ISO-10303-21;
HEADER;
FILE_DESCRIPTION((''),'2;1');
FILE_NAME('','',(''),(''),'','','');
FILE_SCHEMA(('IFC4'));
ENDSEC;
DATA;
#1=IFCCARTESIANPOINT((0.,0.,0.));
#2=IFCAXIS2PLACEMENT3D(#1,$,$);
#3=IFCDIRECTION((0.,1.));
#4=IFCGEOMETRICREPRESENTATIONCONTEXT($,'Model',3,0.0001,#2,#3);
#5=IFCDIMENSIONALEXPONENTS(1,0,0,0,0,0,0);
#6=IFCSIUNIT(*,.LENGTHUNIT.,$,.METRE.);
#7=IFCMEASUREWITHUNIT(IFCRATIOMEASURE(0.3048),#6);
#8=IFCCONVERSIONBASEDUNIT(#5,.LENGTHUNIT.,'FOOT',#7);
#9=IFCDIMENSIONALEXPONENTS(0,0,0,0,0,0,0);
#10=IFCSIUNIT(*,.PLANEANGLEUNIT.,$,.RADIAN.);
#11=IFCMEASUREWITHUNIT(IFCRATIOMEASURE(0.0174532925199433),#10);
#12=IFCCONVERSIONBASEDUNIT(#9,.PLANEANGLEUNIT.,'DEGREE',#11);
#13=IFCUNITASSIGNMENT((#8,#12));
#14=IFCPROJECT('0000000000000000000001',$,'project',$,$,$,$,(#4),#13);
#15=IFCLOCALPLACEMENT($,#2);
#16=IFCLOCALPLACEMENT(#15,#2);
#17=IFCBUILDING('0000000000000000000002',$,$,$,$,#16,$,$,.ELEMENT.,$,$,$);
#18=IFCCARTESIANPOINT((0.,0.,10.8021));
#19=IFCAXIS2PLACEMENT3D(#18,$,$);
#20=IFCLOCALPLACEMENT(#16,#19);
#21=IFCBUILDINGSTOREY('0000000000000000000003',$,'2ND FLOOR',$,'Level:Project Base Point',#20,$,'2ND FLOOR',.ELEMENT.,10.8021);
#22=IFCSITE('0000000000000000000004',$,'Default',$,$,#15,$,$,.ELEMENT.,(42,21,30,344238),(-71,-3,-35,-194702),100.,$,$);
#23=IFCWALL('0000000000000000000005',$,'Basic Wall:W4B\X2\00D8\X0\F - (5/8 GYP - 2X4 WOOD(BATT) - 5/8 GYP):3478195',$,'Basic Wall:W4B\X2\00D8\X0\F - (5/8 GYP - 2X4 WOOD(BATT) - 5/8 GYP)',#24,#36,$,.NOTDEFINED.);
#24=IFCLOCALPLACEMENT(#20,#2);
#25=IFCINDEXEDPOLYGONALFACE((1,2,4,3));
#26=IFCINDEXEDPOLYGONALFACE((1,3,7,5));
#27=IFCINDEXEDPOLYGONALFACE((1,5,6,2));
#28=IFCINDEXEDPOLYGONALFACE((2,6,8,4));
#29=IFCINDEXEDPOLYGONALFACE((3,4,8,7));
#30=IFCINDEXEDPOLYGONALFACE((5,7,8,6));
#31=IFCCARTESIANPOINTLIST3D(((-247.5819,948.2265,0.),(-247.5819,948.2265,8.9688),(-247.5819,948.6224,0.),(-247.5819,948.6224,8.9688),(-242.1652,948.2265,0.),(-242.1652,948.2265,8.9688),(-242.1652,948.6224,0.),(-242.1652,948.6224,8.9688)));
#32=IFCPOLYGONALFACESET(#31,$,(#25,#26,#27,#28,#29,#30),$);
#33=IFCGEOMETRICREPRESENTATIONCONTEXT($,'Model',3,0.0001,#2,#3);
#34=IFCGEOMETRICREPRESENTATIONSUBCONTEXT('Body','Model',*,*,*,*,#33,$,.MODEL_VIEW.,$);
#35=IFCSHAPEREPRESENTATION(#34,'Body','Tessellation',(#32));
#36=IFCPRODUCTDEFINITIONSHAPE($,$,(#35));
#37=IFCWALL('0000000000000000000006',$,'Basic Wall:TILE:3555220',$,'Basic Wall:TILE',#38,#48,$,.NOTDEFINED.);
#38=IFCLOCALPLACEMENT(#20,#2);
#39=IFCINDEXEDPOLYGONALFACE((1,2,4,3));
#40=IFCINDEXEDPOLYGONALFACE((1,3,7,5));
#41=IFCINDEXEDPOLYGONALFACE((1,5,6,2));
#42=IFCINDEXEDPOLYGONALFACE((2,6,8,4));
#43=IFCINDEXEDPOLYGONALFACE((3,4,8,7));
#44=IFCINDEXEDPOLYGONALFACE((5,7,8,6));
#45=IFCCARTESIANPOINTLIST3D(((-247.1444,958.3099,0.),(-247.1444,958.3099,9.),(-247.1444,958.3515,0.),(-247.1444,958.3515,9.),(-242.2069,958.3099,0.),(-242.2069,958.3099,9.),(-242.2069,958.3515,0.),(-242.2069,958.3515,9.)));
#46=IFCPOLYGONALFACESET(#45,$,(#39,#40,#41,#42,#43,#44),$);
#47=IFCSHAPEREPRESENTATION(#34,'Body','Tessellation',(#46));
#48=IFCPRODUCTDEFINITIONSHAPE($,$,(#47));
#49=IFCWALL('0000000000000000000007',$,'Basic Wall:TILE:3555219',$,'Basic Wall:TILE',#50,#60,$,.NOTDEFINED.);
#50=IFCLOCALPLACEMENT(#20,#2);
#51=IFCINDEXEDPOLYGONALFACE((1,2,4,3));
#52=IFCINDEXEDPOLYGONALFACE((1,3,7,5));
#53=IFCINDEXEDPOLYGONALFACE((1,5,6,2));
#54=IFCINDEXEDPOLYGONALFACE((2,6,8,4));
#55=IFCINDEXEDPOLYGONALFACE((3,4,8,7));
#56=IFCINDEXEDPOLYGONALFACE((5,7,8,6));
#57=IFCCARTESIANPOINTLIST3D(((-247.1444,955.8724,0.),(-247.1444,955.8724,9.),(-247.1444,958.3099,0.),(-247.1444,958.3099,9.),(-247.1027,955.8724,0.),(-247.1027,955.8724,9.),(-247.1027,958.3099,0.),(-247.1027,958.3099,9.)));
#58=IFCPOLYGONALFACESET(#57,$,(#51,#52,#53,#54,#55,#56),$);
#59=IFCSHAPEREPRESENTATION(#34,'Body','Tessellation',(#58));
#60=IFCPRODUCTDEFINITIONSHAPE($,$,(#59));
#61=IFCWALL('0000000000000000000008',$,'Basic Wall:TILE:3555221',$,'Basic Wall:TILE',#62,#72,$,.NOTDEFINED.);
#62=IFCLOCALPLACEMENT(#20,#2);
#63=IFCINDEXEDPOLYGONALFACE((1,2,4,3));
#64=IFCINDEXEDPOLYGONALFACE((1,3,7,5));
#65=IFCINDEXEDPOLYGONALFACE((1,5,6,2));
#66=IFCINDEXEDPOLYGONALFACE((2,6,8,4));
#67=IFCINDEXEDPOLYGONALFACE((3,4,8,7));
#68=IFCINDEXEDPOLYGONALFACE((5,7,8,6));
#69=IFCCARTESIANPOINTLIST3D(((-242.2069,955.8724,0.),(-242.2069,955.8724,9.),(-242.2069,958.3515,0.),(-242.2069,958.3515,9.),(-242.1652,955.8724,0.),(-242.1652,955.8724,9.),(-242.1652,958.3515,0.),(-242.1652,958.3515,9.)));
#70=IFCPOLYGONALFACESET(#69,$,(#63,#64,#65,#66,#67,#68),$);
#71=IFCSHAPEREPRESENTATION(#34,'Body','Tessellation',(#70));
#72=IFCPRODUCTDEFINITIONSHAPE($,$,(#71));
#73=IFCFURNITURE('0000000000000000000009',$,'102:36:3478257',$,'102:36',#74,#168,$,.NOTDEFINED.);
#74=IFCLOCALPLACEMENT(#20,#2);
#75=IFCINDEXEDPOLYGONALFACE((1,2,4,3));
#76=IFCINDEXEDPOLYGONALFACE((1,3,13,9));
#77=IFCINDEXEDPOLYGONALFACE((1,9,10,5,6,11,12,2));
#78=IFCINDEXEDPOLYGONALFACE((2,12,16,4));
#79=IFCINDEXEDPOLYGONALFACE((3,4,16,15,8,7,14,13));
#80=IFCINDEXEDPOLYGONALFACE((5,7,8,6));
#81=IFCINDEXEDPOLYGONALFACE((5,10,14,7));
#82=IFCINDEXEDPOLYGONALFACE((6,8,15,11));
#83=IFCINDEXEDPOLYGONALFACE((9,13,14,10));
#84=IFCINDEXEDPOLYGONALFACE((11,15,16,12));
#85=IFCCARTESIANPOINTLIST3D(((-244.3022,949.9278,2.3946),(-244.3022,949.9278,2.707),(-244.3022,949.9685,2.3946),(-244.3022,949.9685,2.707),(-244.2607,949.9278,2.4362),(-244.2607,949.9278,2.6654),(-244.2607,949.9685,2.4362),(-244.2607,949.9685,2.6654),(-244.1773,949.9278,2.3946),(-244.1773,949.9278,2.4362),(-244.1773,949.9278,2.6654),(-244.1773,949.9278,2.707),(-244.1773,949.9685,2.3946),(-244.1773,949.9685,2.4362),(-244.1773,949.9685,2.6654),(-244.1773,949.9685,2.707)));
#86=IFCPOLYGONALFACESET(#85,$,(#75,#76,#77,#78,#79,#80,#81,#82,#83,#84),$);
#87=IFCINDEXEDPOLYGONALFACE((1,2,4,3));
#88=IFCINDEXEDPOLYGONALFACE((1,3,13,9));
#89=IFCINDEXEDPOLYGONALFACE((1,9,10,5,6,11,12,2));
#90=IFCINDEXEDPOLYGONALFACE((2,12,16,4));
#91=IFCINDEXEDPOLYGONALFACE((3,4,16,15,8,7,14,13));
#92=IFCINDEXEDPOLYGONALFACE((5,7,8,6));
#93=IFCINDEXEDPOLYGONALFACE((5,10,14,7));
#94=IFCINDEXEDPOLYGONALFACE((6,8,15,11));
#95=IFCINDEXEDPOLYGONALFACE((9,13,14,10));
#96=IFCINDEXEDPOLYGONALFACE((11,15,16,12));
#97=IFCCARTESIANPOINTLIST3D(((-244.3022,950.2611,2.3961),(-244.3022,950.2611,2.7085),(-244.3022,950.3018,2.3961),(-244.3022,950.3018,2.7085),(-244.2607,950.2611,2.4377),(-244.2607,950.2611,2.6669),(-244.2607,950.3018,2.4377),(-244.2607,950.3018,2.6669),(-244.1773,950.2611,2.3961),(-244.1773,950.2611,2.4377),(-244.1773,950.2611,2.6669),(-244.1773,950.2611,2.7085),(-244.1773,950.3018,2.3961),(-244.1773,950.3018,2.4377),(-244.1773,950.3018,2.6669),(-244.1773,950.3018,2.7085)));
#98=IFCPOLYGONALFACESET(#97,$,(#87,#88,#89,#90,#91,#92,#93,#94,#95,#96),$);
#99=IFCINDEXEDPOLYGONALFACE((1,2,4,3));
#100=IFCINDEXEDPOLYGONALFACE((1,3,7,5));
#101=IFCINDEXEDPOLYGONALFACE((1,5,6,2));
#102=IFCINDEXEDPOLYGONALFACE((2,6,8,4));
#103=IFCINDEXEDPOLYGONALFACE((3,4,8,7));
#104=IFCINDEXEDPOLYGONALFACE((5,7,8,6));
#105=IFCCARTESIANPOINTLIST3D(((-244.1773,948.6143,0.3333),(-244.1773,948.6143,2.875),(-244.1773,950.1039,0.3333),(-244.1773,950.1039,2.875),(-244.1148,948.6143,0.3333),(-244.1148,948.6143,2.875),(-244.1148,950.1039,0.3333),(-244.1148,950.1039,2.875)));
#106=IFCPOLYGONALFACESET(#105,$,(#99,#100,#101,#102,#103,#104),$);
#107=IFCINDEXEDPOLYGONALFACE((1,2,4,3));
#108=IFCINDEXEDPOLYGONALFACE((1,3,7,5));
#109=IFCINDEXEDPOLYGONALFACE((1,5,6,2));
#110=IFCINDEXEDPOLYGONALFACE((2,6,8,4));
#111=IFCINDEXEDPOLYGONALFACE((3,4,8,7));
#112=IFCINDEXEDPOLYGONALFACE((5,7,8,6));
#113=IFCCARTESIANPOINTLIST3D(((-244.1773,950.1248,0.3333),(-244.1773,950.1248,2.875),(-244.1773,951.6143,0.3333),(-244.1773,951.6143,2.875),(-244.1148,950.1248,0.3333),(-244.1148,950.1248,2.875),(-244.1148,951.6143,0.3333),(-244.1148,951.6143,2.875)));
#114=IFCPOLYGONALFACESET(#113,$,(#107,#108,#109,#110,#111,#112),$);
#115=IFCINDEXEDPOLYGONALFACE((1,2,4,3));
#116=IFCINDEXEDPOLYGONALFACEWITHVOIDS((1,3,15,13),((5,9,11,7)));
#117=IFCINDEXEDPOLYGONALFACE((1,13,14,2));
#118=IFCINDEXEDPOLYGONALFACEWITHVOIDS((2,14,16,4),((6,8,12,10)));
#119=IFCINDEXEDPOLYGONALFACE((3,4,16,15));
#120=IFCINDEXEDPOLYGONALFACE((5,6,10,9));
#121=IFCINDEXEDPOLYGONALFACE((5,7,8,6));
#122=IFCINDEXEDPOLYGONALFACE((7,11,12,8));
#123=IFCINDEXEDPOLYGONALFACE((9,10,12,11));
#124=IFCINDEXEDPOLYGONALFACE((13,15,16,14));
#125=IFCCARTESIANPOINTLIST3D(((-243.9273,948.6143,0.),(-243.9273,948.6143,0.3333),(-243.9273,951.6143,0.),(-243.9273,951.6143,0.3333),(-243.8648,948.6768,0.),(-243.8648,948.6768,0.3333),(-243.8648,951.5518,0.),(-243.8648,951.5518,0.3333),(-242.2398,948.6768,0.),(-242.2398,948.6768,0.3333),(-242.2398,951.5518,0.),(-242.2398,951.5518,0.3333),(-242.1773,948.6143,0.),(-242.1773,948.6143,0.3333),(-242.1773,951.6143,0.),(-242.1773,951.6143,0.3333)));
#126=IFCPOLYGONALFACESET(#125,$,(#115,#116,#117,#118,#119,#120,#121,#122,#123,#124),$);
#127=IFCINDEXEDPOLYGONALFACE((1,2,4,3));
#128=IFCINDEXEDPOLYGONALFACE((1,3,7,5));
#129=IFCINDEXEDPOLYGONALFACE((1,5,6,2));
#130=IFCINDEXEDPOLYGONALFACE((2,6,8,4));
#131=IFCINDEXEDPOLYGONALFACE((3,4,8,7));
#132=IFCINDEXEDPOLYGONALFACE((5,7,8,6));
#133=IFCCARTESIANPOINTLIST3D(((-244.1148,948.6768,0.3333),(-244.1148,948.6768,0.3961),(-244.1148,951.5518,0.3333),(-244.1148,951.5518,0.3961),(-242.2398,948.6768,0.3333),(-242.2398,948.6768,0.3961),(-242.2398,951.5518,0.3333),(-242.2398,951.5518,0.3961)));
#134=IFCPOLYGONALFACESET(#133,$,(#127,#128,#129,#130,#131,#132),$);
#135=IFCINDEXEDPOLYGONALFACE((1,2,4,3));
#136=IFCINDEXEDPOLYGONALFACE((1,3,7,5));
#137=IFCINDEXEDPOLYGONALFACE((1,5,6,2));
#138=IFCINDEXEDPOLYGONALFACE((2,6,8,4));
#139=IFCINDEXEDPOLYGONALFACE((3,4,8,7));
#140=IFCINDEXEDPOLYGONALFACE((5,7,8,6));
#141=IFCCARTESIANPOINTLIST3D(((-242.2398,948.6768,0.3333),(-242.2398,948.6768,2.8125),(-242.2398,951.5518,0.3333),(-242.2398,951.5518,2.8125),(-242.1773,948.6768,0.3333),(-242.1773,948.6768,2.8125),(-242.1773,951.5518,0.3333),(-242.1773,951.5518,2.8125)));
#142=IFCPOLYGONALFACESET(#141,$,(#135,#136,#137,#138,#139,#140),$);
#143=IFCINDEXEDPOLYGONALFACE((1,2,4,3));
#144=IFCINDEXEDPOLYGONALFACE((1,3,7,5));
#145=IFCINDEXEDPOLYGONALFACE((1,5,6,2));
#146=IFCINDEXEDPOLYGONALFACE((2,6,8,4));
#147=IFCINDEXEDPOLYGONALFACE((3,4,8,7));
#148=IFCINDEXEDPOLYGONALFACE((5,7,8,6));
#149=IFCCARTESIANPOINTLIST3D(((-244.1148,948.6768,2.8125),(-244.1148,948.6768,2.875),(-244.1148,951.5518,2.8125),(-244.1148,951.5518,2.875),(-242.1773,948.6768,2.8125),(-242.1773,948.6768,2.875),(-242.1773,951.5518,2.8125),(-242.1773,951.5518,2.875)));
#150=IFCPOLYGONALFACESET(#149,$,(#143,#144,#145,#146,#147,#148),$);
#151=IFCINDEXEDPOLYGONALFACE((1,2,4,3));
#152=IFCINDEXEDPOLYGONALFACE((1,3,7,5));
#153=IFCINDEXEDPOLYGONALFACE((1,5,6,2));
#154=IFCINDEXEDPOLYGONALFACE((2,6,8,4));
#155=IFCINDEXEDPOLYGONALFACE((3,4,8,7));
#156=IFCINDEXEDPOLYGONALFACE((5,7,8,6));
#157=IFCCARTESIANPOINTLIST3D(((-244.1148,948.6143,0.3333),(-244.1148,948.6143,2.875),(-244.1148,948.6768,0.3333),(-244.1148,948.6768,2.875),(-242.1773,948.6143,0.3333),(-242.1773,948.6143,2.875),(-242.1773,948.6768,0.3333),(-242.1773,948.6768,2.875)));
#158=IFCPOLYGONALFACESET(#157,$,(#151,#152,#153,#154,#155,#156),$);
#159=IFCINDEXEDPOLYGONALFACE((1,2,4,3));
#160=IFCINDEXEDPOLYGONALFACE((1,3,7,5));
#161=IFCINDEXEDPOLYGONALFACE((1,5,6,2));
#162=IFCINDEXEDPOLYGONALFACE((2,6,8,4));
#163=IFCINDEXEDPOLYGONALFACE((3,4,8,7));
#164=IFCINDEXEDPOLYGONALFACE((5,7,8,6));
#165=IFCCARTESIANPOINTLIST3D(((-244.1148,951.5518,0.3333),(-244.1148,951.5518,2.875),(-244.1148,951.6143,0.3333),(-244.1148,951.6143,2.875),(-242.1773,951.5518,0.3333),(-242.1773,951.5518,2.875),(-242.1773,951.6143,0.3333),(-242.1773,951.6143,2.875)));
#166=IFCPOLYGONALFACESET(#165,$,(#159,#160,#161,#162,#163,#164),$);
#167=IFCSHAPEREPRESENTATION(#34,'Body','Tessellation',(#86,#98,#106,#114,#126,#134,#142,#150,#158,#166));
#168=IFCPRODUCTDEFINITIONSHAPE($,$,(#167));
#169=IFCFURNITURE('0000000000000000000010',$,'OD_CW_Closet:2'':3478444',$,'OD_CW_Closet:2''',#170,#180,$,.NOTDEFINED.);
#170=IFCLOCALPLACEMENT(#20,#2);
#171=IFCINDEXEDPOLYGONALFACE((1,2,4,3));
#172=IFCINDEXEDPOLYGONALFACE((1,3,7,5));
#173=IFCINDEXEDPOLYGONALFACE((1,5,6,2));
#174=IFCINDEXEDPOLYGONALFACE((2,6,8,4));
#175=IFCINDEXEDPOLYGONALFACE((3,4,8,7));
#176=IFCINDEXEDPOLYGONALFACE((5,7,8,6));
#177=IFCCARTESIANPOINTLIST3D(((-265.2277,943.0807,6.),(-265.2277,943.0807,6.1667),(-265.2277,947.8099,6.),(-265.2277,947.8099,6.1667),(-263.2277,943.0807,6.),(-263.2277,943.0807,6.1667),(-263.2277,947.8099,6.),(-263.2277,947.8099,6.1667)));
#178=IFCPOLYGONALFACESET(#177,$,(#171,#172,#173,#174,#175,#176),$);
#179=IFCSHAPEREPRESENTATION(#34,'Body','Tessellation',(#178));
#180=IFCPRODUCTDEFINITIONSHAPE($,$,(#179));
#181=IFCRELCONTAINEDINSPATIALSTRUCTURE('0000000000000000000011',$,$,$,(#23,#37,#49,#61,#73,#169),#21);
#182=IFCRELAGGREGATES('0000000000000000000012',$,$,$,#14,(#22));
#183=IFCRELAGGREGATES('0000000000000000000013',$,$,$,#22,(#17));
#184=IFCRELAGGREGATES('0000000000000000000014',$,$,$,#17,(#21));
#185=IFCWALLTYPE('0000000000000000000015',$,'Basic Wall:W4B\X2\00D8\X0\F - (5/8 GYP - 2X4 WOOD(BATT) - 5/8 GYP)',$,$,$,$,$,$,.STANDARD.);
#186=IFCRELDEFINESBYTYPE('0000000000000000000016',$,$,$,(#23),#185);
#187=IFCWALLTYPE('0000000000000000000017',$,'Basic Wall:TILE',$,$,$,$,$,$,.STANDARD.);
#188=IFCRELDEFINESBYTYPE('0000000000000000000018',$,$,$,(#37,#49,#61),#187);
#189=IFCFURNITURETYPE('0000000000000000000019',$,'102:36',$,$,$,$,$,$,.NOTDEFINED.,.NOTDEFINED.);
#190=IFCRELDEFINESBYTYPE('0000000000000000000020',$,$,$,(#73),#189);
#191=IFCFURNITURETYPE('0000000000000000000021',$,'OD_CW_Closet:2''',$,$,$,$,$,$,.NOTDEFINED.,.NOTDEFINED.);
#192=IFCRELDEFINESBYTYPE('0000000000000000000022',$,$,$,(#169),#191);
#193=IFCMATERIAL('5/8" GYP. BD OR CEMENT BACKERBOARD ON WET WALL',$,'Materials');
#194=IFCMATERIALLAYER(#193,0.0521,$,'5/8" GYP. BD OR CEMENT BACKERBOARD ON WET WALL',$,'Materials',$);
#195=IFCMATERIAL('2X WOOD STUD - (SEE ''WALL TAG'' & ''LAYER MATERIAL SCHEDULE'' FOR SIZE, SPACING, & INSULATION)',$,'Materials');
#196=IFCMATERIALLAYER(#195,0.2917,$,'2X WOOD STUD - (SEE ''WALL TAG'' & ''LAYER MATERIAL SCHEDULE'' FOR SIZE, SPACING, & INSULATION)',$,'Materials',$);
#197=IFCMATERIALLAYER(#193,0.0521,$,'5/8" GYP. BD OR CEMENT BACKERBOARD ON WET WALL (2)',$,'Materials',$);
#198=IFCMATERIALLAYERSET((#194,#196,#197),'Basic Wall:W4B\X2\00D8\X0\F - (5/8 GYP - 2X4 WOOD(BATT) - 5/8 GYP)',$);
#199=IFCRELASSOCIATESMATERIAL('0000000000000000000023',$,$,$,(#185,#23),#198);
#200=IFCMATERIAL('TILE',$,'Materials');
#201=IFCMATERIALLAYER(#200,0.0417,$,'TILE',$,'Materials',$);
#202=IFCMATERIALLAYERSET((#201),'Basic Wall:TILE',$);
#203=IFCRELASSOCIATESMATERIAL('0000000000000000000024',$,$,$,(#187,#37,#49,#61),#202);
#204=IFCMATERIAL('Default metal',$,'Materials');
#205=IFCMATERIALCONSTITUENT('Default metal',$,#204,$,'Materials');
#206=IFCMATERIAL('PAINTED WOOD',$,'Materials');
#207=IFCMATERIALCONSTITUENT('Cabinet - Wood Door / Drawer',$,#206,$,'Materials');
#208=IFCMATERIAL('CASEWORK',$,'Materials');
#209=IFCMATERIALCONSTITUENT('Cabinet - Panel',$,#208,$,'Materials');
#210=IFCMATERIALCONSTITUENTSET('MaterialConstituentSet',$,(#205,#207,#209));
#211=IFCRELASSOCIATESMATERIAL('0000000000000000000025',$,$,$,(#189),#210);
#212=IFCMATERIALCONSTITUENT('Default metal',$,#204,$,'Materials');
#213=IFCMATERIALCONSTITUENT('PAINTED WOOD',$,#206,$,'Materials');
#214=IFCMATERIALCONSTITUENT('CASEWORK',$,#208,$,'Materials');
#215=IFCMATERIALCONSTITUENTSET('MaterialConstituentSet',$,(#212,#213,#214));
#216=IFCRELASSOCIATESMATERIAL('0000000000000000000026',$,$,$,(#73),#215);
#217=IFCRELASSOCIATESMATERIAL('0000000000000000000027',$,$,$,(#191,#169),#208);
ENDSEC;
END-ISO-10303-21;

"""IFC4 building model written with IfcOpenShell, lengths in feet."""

from ifc_helpers import new_model, entity, si_unit, converted_unit, direction, frame, frame_2d, origin, origin_2d_with_axis, place, context, subcontext, project, spatial, polyline, rectangle, outline, extrude, source, transform, mapped, material, layer, layer_set, layer_usage, constituent, constituent_set, type_object, type_shapes, element, save


model = new_model("IFC4")

# Units and contexts
model_context_1 = context("Model", 3, precision=0.0001, world=origin(), true_north=direction((0.0, 1.0)))
model_context_2 = context("Model", 3, precision=0.0001, world=origin(), true_north=direction((0.0, 1.0)))
body_context = subcontext(model_context_2, "Body", "Model", "MODEL_VIEW")
ifc_project = project(units=[converted_unit("LENGTHUNIT", "FOOT", entity("IfcRatioMeasure", 0.3048), si_unit("LENGTHUNIT", "METRE"), dimensions=[1, 0, 0, 0, 0, 0, 0]), converted_unit("PLANEANGLEUNIT", "DEGREE", entity("IfcRatioMeasure", 0.0174532925199433), si_unit("PLANEANGLEUNIT", "RADIAN"), dimensions=[0, 0, 0, 0, 0, 0, 0])], contexts=[model_context_1])

# Site, building, storey
site_placement = place(None, origin())
site = spatial("IfcSite", under=ifc_project, at=site_placement, Name="Default", CompositionType="ELEMENT", RefLatitude=(42, 21, 30, 344238), RefLongitude=(-71, -3, -35, -194702), RefElevation=100.0)
building_placement = place(site_placement, origin())
building = spatial("IfcBuilding", under=site, at=building_placement, CompositionType="ELEMENT")
storey_placement = place(building_placement, frame((0.0, 0.0, 10.8021)))
storey = spatial("IfcBuildingStorey", under=building, at=storey_placement, Name="2ND FLOOR", ObjectType="Level:Project Base Point", LongName="2ND FLOOR", CompositionType="ELEMENT", Elevation=10.8021)

# Shared definitions
ifc_material_1 = material(Name="5/8\" GYP. BD OR CEMENT BACKERBOARD ON WET WALL", Category="Materials")
ifc_layer_1 = layer(ifc_material_1, 0.0521, Name="5/8\" GYP. BD OR CEMENT BACKERBOARD ON WET WALL", Category="Materials")
ifc_material_2 = material(Name="2X WOOD STUD - (SEE 'WALL TAG' & 'LAYER MATERIAL SCHEDULE' FOR SIZE, SPACING, & INSULATION)", Category="Materials")
ifc_layer_2 = layer(ifc_material_2, 0.2917, Name="2X WOOD STUD - (SEE 'WALL TAG' & 'LAYER MATERIAL SCHEDULE' FOR SIZE, SPACING, & INSULATION)", Category="Materials")
ifc_layer_3 = layer(ifc_material_1, 0.0521, Name="5/8\" GYP. BD OR CEMENT BACKERBOARD ON WET WALL (2)", Category="Materials")
ifc_layer_set_1 = layer_set([ifc_layer_1, ifc_layer_2, ifc_layer_3], Name="Basic Wall:W4BØF - (5/8 GYP - 2X4 WOOD(BATT) - 5/8 GYP)")
wall_type_1 = type_object("IfcWallType", Name="Basic Wall:W4BØF - (5/8 GYP - 2X4 WOOD(BATT) - 5/8 GYP)", PredefinedType="STANDARD", material=ifc_layer_set_1)

# Wall
ifc_layer_usage_1 = layer_usage(ifc_layer_set_1, "AXIS2", "NEGATIVE", 0.1979)
wall_1_placement = place(storey_placement, frame((-247.5819, 948.4244, 0.0)))
element("IfcWall", 1, at=wall_1_placement, inside=storey, type_object=wall_type_1, material=ifc_layer_usage_1, Name="Basic Wall:W4BØF - (5/8 GYP - 2X4 WOOD(BATT) - 5/8 GYP):3478195", ObjectType="Basic Wall:W4BØF - (5/8 GYP - 2X4 WOOD(BATT) - 5/8 GYP)", PredefinedType="NOTDEFINED", context=body_context, shape_type="SweptSolid", body=[
    extrude(rectangle(XDim=5.4167, YDim=0.3958, at=frame_2d((2.7083, 0.0), x_axis=(-1.0, 0.0))), origin(), (0.0, 0.0, 1.0), 8.9688),
])

# Walls
ifc_material_3 = material(Name="TILE", Category="Materials")
ifc_layer_4 = layer(ifc_material_3, 0.0417, Name="TILE", Category="Materials")
ifc_layer_set_2 = layer_set([ifc_layer_4], Name="Basic Wall:TILE")
ifc_layer_usage_2 = layer_usage(ifc_layer_set_2, "AXIS2", "NEGATIVE", 0.0208)
wall_type_2 = type_object("IfcWallType", Name="Basic Wall:TILE", PredefinedType="STANDARD", material=ifc_layer_set_2)
wall_2_placement = place(storey_placement, frame((-247.1444, 958.3307, 0.0)))
element("IfcWall", 2, at=wall_2_placement, inside=storey, type_object=wall_type_2, material=ifc_layer_usage_2, Name="Basic Wall:TILE:3555220", ObjectType="Basic Wall:TILE", PredefinedType="NOTDEFINED", context=body_context, shape_type="SweptSolid", body=[
    extrude(rectangle(XDim=4.9375, YDim=0.0417, at=frame_2d((2.4688, 0.0), x_axis=(-1.0, 0.0))), origin(), (0.0, 0.0, 1.0), 9.0),
])
ifc_layer_usage_3 = layer_usage(ifc_layer_set_2, "AXIS2", "NEGATIVE", 0.0208)
wall_3_placement = place(storey_placement, frame((-247.1236, 955.8724, 0.0), z_axis=(0.0, 0.0, 1.0), x_axis=(0.0, 1.0, 0.0)))
element("IfcWall", 3, at=wall_3_placement, inside=storey, type_object=wall_type_2, material=ifc_layer_usage_3, Name="Basic Wall:TILE:3555219", ObjectType="Basic Wall:TILE", PredefinedType="NOTDEFINED", context=body_context, shape_type="SweptSolid", body=[
    extrude(rectangle(XDim=2.4375, YDim=0.0417, at=frame_2d((1.2187, 0.0), x_axis=(-1.0, 0.0))), origin(), (0.0, 0.0, 1.0), 9.0),
])
ifc_layer_usage_4 = layer_usage(ifc_layer_set_2, "AXIS2", "NEGATIVE", 0.0208)
wall_4_placement = place(storey_placement, frame((-242.1861, 958.3515, 0.0), z_axis=(0.0, 0.0, 1.0), x_axis=(0.0, -1.0, 0.0)))
element("IfcWall", 4, at=wall_4_placement, inside=storey, type_object=wall_type_2, material=ifc_layer_usage_4, Name="Basic Wall:TILE:3555221", ObjectType="Basic Wall:TILE", PredefinedType="NOTDEFINED", context=body_context, shape_type="SweptSolid", body=[
    extrude(rectangle(XDim=2.4792, YDim=0.0417, at=frame_2d((1.2396, 0.0), x_axis=(-1.0, 0.0))), origin(), (0.0, 0.0, 1.0), 9.0),
])

# Furniture
ifc_material_4 = material(Name="Default metal", Category="Materials")
ifc_material_5 = material(Name="PAINTED WOOD", Category="Materials")
ifc_material_6 = material(Name="CASEWORK", Category="Materials")
ifc_constituent_1 = constituent(ifc_material_4, Name="Default metal", Category="Materials")
ifc_constituent_2 = constituent(ifc_material_5, Name="PAINTED WOOD", Category="Materials")
ifc_constituent_3 = constituent(ifc_material_6, Name="CASEWORK", Category="Materials")
ifc_constituent_set_1 = constituent_set(constituents=[ifc_constituent_1, ifc_constituent_2, ifc_constituent_3], Name="MaterialConstituentSet")
ifc_constituent_4 = constituent(ifc_material_4, Name="Default metal", Category="Materials")
ifc_constituent_5 = constituent(ifc_material_5, Name="Cabinet - Wood Door / Drawer", Category="Materials")
ifc_constituent_6 = constituent(ifc_material_6, Name="Cabinet - Panel", Category="Materials")
ifc_constituent_set_2 = constituent_set(constituents=[ifc_constituent_4, ifc_constituent_5, ifc_constituent_6], Name="MaterialConstituentSet")
furniture_type_1 = type_object("IfcFurnitureType", Name="102:36", AssemblyPlace="NOTDEFINED", PredefinedType="NOTDEFINED", material=ifc_constituent_set_2)
shared_shape_1 = source(origin(), body_context, "Body", "SweptSolid", [
    extrude(outline(polyline([(0.1146, -0.0521), (0.1562, -0.0521), (0.1562, 0.0729), (-0.1562, 0.0729), (-0.1562, -0.0521), (-0.1146, -0.0521), (-0.1146, 0.0313), (0.1146, 0.0313), (0.1146, -0.0521)])), frame((0.2073, -2.0521, 2.5508), z_axis=(1.0, 0.0, 0.0), x_axis=(0.0, 0.0, 1.0)), (0.0, 0.0, 1.0), 0.0407),
    extrude(outline(polyline([(0.1146, -0.0521), (0.1562, -0.0521), (0.1562, 0.0729), (-0.1562, 0.0729), (-0.1562, -0.0521), (-0.1146, -0.0521), (-0.1146, 0.0313), (0.1146, 0.0313), (0.1146, -0.0521)])), frame((-0.126, -2.0521, 2.5523), z_axis=(1.0, 0.0, 0.0), x_axis=(0.0, 0.0, 1.0)), (0.0, 0.0, 1.0), 0.0407),
    extrude(rectangle(XDim=0.0625, YDim=1.4896, at=frame_2d((0.0, 0.0), x_axis=(1.0, 0.0))), frame((0.8167, -1.9688, 0.3333), z_axis=(0.0, 0.0, 1.0), x_axis=(0.0, 1.0, 0.0)), (0.0, 0.0, 1.0), 2.5417),
    extrude(rectangle(XDim=0.0625, YDim=1.4896, at=origin_2d_with_axis()), frame((-0.6937, -1.9688, 0.3333), z_axis=(0.0, 0.0, 1.0), x_axis=(0.0, 1.0, 0.0)), (0.0, 0.0, 1.0), 2.5417),
    extrude(outline(polyline([(-1.5, -0.875), (1.5, -0.875), (1.5, 0.875), (-1.5, 0.875), (-1.5, -0.875)]), holes=[polyline([(-1.4375, -0.8125), (-1.4375, 0.8125), (1.4375, 0.8125), (1.4375, -0.8125), (-1.4375, -0.8125)])]), frame((0.0615, -0.875, 0.0)), (0.0, 0.0, 1.0), 0.3333),
    extrude(rectangle(XDim=2.875, YDim=1.875, at=origin_2d_with_axis()), frame((0.0615, -1.0, 0.3333), z_axis=(0.0, 0.0, 1.0), x_axis=(-1.0, 0.0, 0.0)), (0.0, 0.0, 1.0), 0.0627),
    extrude(rectangle(XDim=0.0625, YDim=2.875, at=origin_2d_with_axis()), frame((0.0615, -0.0312, 0.3333), z_axis=(0.0, 0.0, 1.0), x_axis=(0.0, 1.0, 0.0)), (0.0, 0.0, 1.0), 2.4792),
    extrude(rectangle(XDim=2.875, YDim=1.9375, at=origin_2d_with_axis()), frame((0.0615, -0.9688, 2.8125), z_axis=(0.0, 0.0, 1.0), x_axis=(-1.0, 0.0, 0.0)), (0.0, 0.0, 1.0), 0.0625),
    extrude(rectangle(XDim=0.0625, YDim=1.9375, at=frame_2d((0.0, 0.0), x_axis=(1.0, 0.0))), frame((1.5302, -0.9687, 0.3333)), (0.0, 0.0, 1.0), 2.5417),
    extrude(rectangle(XDim=0.0625, YDim=1.9375, at=frame_2d((0.0, 0.0), x_axis=(1.0, 0.0))), frame((-1.4073, -0.9687, 0.3333)), (0.0, 0.0, 1.0), 2.5417),
])
type_shapes(furniture_type_1, [shared_shape_1])
furniture_1_placement = place(storey_placement, frame((-242.1773, 950.1758, 0.0), z_axis=(0.0, 0.0, 1.0), x_axis=(0.0, -1.0, 0.0)))
element("IfcFurniture", 5, at=furniture_1_placement, inside=storey, type_object=furniture_type_1, material=ifc_constituent_set_1, Name="102:36:3478257", ObjectType="102:36", PredefinedType="NOTDEFINED", context=body_context, shape_type="MappedRepresentation", body=[
    mapped(shared_shape_1, transform((0.0, 0.0, 0.0), scale=1.0)),
])
furniture_type_2 = type_object("IfcFurnitureType", Name="OD_CW_Closet:2'", AssemblyPlace="NOTDEFINED", PredefinedType="NOTDEFINED", material=ifc_material_6)
shared_shape_2 = source(origin(), body_context, "Body", "SweptSolid", [
    extrude(rectangle(XDim=4.7292, YDim=2.0, at=origin_2d_with_axis()), frame((2.3646, 1.0, 0.0)), (0.0, 0.0, 1.0), 0.1667),
])
type_shapes(furniture_type_2, [shared_shape_2])
furniture_2_placement = place(storey_placement, frame((-265.2277, 947.8099, 6.0), z_axis=(0.0, 0.0, 1.0), x_axis=(0.0, -1.0, 0.0)))
element("IfcFurniture", 6, at=furniture_2_placement, inside=storey, type_object=furniture_type_2, material=ifc_material_6, Name="OD_CW_Closet:2':3478444", ObjectType="OD_CW_Closet:2'", PredefinedType="NOTDEFINED", context=body_context, shape_type="MappedRepresentation", body=[
    mapped(shared_shape_2, transform((0.0, 0.0, 0.0), scale=1.0)),
])

save(model, "model.ifc")
